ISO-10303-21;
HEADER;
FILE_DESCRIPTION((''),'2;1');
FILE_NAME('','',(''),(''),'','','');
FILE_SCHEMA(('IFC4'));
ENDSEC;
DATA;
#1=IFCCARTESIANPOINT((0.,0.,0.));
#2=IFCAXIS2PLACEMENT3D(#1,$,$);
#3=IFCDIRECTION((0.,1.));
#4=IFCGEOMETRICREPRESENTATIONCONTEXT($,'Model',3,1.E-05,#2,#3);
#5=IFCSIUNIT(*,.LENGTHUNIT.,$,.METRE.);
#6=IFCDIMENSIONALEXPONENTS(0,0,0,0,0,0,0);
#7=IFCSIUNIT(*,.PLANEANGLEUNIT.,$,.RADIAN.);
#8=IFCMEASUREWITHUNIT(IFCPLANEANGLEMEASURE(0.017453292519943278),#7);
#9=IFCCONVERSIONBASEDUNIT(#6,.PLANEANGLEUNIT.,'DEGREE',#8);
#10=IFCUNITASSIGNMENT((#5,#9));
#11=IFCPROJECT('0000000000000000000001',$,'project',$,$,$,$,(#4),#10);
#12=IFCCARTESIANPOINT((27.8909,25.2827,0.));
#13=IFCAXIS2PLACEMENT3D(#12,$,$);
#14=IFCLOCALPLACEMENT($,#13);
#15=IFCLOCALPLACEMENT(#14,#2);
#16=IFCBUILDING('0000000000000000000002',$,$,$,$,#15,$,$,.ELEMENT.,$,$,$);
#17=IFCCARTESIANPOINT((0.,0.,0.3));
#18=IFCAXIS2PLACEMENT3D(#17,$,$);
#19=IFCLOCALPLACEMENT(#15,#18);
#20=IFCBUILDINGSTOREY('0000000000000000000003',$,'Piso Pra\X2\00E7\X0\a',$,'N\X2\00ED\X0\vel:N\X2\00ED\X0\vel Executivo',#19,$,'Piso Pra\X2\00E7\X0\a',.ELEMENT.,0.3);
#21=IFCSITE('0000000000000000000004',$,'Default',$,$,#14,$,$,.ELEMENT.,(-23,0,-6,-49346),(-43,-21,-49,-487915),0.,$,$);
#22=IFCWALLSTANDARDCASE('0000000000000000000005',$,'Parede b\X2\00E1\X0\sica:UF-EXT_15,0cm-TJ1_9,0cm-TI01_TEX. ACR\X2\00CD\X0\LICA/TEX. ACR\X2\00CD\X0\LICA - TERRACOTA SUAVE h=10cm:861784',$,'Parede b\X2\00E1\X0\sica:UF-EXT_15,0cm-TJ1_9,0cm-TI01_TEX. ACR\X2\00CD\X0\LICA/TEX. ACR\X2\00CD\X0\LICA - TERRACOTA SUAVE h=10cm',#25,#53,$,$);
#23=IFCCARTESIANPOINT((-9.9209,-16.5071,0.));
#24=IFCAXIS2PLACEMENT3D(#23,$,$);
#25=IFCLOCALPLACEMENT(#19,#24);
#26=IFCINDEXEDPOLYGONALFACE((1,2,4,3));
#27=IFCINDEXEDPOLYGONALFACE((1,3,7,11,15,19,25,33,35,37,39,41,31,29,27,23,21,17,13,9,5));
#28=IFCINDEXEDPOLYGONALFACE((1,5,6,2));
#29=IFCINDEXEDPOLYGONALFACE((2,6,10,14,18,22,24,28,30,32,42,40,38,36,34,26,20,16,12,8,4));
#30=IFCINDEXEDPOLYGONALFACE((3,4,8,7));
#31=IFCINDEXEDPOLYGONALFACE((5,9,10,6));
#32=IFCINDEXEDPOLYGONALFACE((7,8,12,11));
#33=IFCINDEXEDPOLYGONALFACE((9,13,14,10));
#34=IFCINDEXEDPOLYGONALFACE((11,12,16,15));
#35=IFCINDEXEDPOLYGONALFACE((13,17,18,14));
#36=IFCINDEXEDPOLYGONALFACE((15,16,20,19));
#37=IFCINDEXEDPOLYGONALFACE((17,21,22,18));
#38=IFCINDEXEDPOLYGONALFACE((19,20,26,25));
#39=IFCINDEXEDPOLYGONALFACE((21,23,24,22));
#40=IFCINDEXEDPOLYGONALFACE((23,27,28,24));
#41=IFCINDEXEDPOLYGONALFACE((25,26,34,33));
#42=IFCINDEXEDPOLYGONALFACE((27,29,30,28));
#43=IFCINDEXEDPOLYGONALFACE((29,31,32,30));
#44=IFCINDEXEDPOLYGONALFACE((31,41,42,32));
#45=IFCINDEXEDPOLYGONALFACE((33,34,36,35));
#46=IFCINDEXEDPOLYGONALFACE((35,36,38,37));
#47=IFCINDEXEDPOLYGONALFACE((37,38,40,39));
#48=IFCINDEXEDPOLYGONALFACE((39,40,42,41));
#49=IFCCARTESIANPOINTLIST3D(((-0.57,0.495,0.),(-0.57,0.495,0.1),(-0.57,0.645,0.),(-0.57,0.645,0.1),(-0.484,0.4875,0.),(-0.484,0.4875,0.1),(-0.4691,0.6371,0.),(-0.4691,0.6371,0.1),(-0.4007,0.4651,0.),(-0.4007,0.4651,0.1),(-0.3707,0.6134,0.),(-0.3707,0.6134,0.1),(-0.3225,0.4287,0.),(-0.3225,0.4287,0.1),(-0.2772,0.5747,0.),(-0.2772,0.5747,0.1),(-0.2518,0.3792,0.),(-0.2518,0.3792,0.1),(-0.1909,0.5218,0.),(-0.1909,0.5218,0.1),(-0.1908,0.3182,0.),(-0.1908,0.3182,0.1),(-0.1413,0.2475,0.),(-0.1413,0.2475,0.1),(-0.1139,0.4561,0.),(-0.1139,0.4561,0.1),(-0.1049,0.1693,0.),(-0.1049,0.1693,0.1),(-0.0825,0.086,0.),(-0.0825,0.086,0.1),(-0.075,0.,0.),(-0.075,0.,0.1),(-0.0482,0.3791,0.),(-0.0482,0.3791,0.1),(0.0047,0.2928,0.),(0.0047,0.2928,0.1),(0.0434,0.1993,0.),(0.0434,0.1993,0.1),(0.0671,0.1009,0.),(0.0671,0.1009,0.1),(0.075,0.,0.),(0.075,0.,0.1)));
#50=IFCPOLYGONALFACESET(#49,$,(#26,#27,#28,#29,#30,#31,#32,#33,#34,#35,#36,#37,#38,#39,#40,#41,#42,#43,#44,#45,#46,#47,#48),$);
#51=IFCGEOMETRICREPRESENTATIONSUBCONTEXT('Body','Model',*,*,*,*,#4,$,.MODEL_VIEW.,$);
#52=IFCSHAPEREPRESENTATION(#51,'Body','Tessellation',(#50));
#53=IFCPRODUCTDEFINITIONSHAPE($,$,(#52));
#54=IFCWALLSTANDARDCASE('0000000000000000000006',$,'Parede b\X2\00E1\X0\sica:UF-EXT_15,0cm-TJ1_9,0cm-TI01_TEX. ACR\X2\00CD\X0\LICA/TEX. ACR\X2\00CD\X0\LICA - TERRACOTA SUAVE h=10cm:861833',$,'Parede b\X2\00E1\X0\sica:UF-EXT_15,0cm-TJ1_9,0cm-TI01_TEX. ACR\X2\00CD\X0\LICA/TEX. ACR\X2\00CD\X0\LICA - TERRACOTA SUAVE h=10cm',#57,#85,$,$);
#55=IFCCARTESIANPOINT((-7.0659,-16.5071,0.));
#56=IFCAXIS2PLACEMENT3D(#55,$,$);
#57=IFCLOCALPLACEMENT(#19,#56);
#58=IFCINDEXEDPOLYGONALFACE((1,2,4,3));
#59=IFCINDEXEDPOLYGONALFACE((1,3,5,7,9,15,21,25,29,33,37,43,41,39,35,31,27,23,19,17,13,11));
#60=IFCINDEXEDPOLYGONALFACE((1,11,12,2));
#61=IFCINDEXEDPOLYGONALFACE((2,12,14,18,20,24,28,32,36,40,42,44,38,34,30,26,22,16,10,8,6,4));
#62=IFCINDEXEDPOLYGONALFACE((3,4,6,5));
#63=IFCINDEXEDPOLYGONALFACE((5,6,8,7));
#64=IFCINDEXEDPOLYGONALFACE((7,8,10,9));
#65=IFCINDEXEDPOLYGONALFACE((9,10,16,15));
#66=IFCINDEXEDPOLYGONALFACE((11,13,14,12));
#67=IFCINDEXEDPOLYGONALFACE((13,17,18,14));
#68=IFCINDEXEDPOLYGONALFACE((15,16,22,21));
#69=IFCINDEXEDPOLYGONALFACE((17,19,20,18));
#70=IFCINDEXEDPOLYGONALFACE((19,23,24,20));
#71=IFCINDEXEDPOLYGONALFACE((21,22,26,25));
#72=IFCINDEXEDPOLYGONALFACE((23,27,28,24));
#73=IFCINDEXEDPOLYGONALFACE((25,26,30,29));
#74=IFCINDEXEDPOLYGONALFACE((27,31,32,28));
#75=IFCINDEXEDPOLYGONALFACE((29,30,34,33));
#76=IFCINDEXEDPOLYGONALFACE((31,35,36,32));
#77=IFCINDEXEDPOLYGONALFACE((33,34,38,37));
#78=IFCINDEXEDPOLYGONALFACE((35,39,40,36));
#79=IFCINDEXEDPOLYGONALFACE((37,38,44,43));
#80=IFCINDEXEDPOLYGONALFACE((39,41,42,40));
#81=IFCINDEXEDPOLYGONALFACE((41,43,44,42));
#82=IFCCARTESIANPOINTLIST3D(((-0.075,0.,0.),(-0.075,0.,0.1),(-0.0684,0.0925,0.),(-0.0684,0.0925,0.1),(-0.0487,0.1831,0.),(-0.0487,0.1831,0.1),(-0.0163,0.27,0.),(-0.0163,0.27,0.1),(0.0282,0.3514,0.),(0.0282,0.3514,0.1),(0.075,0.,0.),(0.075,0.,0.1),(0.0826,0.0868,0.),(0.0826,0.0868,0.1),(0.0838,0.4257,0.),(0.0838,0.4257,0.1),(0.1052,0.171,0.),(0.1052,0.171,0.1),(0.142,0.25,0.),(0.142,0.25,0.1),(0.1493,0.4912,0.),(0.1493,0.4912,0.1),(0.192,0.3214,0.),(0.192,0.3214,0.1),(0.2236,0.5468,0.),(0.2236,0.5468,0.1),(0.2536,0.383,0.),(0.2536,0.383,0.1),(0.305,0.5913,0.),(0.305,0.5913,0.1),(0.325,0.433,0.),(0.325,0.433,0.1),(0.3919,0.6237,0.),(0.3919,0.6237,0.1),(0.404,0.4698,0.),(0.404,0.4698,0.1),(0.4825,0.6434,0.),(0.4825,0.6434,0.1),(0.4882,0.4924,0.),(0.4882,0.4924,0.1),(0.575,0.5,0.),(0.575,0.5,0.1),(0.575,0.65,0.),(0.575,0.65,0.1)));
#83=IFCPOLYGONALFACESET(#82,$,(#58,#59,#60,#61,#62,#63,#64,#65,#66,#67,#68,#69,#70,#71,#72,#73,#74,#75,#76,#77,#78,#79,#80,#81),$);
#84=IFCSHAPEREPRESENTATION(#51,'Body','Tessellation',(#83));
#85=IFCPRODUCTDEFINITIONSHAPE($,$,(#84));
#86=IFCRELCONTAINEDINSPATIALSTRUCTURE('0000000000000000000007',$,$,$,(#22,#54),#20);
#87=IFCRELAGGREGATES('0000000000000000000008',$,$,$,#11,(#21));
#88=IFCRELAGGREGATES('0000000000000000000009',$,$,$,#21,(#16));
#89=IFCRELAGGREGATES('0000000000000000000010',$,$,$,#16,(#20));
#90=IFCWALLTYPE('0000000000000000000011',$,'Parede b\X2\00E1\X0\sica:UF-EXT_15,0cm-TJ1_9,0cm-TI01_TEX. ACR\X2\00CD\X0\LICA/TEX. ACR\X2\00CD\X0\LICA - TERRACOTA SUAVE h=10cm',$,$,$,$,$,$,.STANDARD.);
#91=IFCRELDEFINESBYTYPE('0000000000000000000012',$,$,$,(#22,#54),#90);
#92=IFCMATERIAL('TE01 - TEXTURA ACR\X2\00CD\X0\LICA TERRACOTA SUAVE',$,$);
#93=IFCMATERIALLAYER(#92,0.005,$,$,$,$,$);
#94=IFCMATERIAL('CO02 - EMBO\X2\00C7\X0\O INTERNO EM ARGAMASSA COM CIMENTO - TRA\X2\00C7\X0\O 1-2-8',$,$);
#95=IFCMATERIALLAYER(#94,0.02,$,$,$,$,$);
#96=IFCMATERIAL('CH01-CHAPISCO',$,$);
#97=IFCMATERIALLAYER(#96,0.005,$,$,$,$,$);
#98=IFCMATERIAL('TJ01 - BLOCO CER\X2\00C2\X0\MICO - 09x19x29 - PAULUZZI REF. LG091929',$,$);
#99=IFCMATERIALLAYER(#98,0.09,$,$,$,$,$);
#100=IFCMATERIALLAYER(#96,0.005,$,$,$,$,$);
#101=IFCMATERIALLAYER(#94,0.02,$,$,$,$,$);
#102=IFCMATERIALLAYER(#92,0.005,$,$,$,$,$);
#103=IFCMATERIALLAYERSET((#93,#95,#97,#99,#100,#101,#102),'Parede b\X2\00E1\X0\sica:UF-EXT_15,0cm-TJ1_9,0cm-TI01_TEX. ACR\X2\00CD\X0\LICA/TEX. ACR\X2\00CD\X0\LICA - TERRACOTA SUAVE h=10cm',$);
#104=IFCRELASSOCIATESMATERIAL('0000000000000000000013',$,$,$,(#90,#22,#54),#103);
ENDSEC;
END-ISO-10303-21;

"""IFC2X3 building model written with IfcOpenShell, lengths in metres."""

from ifc_helpers import new_model, entity, si_unit, converted_unit, direction, frame, frame_2d, origin, place, context, subcontext, project, spatial, polyline, circle_curve, parameter, trimmed, segment, composite_curve, outline, extrude, material, layer, layer_set, layer_usage, type_object, element, save


model = new_model("IFC2X3")

# Units and contexts
model_context = context("Model", 3, precision=1e-05, world=origin(), true_north=direction((0.0, 1.0)))
body_context = subcontext(model_context, "Body", "Model", "MODEL_VIEW")
ifc_project = project(units=[si_unit("LENGTHUNIT", "METRE"), converted_unit("PLANEANGLEUNIT", "DEGREE", entity("IfcPlaneAngleMeasure", 0.017453292519943278), si_unit("PLANEANGLEUNIT", "RADIAN"), dimensions=[0, 0, 0, 0, 0, 0, 0])], contexts=[model_context])

# Site, building, storey
site_placement = place(None, frame((27.8909, 25.2827, 0.0)))
site = spatial("IfcSite", under=ifc_project, at=site_placement, Name="Default", CompositionType="ELEMENT", RefLatitude=(-23, 0, -6, -49346), RefLongitude=(-43, -21, -49, -487915), RefElevation=0.0)
building_placement = place(site_placement, origin())
building = spatial("IfcBuilding", under=site, at=building_placement, CompositionType="ELEMENT")
storey_placement = place(building_placement, frame((0.0, 0.0, 0.3)))
storey = spatial("IfcBuildingStorey", under=building, at=storey_placement, Name="Piso Praça", ObjectType="Nível:Nível Executivo", LongName="Piso Praça", CompositionType="ELEMENT", Elevation=0.3)

# Walls
ifc_material_1 = material(Name="CO02 - EMBOÇO INTERNO EM ARGAMASSA COM CIMENTO - TRAÇO 1-2-8")
ifc_material_2 = material(Name="CH01-CHAPISCO")
ifc_material_3 = material(Name="TJ01 - BLOCO CERÂMICO - 09x19x29 - PAULUZZI REF. LG091929")
ifc_material_4 = material(Name="TE01 - TEXTURA ACRÍLICA TERRACOTA SUAVE")
ifc_layer_1 = layer(ifc_material_4, 0.005)
ifc_layer_2 = layer(ifc_material_1, 0.02)
ifc_layer_3 = layer(ifc_material_2, 0.005)
ifc_layer_4 = layer(ifc_material_3, 0.09)
ifc_layer_5 = layer(ifc_material_2, 0.005)
ifc_layer_6 = layer(ifc_material_1, 0.02)
ifc_layer_7 = layer(ifc_material_4, 0.005)
ifc_layer_set_1 = layer_set([ifc_layer_1, ifc_layer_2, ifc_layer_3, ifc_layer_4, ifc_layer_5, ifc_layer_6, ifc_layer_7], Name="Parede básica:UF-EXT_15,0cm-TJ1_9,0cm-TI01_TEX. ACRÍLICA/TEX. ACRÍLICA - TERRACOTA SUAVE h=10cm")
ifc_layer_usage_1 = layer_usage(ifc_layer_set_1, "AXIS2", "NEGATIVE", 0.075)
wall_type_1 = type_object("IfcWallType", Name="Parede básica:UF-EXT_15,0cm-TJ1_9,0cm-TI01_TEX. ACRÍLICA/TEX. ACRÍLICA - TERRACOTA SUAVE h=10cm", PredefinedType="STANDARD", material=ifc_layer_set_1)
ifc_layer_usage_2 = layer_usage(ifc_layer_set_1, "AXIS2", "POSITIVE", -0.075)
wall_1_placement = place(storey_placement, frame((-9.9209, -16.5071, 0.0)))
element("IfcWallStandardCase", 1, at=wall_1_placement, inside=storey, type_object=wall_type_1, material=ifc_layer_usage_1, Name="Parede básica:UF-EXT_15,0cm-TJ1_9,0cm-TI01_TEX. ACRÍLICA/TEX. ACRÍLICA - TERRACOTA SUAVE h=10cm:861784", ObjectType="Parede básica:UF-EXT_15,0cm-TJ1_9,0cm-TI01_TEX. ACRÍLICA/TEX. ACRÍLICA - TERRACOTA SUAVE h=10cm", context=body_context, shape_type="SweptSolid", body=[
    extrude(outline(composite_curve([segment(trimmed(circle_curve(frame_2d((-0.57, 0.0), x_axis=(1.0, 0.0)), 0.495), [parameter(0.0)], [parameter(90.0)], True, "PARAMETER"), False, "CONTINUOUS"), segment(polyline([(-0.075, 0.0), (0.075, 0.0)]), True, "CONTINUOUS"), segment(trimmed(circle_curve(frame_2d((-0.57, 0.0), x_axis=(1.0, 0.0)), 0.645), [parameter(0.0)], [parameter(90.0)], True, "PARAMETER"), True, "CONTINUOUS"), segment(polyline([(-0.57, 0.645), (-0.57, 0.495)]), True, "CONTINUOUS")], self_intersect=False)), origin(), (0.0, 0.0, 1.0), 0.1),
])
wall_2_placement = place(storey_placement, frame((-7.0659, -16.5071, 0.0)))
element("IfcWallStandardCase", 2, at=wall_2_placement, inside=storey, type_object=wall_type_1, material=ifc_layer_usage_2, Name="Parede básica:UF-EXT_15,0cm-TJ1_9,0cm-TI01_TEX. ACRÍLICA/TEX. ACRÍLICA - TERRACOTA SUAVE h=10cm:861833", ObjectType="Parede básica:UF-EXT_15,0cm-TJ1_9,0cm-TI01_TEX. ACRÍLICA/TEX. ACRÍLICA - TERRACOTA SUAVE h=10cm", context=body_context, shape_type="SweptSolid", body=[
    extrude(outline(composite_curve([segment(trimmed(circle_curve(frame_2d((0.575, 0.0), x_axis=(1.0, 0.0)), 0.65), [parameter(90.0)], [parameter(180.0)], True, "PARAMETER"), True, "CONTINUOUS"), segment(polyline([(-0.075, 0.0), (0.075, 0.0)]), True, "CONTINUOUS"), segment(trimmed(circle_curve(frame_2d((0.575, 0.0), x_axis=(1.0, 0.0)), 0.5), [parameter(90.0)], [parameter(180.0)], True, "PARAMETER"), False, "CONTINUOUS"), segment(polyline([(0.575, 0.5), (0.575, 0.65)]), True, "CONTINUOUS")], self_intersect=False)), origin(), (0.0, 0.0, 1.0), 0.1),
])

save(model, "model.ifc")
